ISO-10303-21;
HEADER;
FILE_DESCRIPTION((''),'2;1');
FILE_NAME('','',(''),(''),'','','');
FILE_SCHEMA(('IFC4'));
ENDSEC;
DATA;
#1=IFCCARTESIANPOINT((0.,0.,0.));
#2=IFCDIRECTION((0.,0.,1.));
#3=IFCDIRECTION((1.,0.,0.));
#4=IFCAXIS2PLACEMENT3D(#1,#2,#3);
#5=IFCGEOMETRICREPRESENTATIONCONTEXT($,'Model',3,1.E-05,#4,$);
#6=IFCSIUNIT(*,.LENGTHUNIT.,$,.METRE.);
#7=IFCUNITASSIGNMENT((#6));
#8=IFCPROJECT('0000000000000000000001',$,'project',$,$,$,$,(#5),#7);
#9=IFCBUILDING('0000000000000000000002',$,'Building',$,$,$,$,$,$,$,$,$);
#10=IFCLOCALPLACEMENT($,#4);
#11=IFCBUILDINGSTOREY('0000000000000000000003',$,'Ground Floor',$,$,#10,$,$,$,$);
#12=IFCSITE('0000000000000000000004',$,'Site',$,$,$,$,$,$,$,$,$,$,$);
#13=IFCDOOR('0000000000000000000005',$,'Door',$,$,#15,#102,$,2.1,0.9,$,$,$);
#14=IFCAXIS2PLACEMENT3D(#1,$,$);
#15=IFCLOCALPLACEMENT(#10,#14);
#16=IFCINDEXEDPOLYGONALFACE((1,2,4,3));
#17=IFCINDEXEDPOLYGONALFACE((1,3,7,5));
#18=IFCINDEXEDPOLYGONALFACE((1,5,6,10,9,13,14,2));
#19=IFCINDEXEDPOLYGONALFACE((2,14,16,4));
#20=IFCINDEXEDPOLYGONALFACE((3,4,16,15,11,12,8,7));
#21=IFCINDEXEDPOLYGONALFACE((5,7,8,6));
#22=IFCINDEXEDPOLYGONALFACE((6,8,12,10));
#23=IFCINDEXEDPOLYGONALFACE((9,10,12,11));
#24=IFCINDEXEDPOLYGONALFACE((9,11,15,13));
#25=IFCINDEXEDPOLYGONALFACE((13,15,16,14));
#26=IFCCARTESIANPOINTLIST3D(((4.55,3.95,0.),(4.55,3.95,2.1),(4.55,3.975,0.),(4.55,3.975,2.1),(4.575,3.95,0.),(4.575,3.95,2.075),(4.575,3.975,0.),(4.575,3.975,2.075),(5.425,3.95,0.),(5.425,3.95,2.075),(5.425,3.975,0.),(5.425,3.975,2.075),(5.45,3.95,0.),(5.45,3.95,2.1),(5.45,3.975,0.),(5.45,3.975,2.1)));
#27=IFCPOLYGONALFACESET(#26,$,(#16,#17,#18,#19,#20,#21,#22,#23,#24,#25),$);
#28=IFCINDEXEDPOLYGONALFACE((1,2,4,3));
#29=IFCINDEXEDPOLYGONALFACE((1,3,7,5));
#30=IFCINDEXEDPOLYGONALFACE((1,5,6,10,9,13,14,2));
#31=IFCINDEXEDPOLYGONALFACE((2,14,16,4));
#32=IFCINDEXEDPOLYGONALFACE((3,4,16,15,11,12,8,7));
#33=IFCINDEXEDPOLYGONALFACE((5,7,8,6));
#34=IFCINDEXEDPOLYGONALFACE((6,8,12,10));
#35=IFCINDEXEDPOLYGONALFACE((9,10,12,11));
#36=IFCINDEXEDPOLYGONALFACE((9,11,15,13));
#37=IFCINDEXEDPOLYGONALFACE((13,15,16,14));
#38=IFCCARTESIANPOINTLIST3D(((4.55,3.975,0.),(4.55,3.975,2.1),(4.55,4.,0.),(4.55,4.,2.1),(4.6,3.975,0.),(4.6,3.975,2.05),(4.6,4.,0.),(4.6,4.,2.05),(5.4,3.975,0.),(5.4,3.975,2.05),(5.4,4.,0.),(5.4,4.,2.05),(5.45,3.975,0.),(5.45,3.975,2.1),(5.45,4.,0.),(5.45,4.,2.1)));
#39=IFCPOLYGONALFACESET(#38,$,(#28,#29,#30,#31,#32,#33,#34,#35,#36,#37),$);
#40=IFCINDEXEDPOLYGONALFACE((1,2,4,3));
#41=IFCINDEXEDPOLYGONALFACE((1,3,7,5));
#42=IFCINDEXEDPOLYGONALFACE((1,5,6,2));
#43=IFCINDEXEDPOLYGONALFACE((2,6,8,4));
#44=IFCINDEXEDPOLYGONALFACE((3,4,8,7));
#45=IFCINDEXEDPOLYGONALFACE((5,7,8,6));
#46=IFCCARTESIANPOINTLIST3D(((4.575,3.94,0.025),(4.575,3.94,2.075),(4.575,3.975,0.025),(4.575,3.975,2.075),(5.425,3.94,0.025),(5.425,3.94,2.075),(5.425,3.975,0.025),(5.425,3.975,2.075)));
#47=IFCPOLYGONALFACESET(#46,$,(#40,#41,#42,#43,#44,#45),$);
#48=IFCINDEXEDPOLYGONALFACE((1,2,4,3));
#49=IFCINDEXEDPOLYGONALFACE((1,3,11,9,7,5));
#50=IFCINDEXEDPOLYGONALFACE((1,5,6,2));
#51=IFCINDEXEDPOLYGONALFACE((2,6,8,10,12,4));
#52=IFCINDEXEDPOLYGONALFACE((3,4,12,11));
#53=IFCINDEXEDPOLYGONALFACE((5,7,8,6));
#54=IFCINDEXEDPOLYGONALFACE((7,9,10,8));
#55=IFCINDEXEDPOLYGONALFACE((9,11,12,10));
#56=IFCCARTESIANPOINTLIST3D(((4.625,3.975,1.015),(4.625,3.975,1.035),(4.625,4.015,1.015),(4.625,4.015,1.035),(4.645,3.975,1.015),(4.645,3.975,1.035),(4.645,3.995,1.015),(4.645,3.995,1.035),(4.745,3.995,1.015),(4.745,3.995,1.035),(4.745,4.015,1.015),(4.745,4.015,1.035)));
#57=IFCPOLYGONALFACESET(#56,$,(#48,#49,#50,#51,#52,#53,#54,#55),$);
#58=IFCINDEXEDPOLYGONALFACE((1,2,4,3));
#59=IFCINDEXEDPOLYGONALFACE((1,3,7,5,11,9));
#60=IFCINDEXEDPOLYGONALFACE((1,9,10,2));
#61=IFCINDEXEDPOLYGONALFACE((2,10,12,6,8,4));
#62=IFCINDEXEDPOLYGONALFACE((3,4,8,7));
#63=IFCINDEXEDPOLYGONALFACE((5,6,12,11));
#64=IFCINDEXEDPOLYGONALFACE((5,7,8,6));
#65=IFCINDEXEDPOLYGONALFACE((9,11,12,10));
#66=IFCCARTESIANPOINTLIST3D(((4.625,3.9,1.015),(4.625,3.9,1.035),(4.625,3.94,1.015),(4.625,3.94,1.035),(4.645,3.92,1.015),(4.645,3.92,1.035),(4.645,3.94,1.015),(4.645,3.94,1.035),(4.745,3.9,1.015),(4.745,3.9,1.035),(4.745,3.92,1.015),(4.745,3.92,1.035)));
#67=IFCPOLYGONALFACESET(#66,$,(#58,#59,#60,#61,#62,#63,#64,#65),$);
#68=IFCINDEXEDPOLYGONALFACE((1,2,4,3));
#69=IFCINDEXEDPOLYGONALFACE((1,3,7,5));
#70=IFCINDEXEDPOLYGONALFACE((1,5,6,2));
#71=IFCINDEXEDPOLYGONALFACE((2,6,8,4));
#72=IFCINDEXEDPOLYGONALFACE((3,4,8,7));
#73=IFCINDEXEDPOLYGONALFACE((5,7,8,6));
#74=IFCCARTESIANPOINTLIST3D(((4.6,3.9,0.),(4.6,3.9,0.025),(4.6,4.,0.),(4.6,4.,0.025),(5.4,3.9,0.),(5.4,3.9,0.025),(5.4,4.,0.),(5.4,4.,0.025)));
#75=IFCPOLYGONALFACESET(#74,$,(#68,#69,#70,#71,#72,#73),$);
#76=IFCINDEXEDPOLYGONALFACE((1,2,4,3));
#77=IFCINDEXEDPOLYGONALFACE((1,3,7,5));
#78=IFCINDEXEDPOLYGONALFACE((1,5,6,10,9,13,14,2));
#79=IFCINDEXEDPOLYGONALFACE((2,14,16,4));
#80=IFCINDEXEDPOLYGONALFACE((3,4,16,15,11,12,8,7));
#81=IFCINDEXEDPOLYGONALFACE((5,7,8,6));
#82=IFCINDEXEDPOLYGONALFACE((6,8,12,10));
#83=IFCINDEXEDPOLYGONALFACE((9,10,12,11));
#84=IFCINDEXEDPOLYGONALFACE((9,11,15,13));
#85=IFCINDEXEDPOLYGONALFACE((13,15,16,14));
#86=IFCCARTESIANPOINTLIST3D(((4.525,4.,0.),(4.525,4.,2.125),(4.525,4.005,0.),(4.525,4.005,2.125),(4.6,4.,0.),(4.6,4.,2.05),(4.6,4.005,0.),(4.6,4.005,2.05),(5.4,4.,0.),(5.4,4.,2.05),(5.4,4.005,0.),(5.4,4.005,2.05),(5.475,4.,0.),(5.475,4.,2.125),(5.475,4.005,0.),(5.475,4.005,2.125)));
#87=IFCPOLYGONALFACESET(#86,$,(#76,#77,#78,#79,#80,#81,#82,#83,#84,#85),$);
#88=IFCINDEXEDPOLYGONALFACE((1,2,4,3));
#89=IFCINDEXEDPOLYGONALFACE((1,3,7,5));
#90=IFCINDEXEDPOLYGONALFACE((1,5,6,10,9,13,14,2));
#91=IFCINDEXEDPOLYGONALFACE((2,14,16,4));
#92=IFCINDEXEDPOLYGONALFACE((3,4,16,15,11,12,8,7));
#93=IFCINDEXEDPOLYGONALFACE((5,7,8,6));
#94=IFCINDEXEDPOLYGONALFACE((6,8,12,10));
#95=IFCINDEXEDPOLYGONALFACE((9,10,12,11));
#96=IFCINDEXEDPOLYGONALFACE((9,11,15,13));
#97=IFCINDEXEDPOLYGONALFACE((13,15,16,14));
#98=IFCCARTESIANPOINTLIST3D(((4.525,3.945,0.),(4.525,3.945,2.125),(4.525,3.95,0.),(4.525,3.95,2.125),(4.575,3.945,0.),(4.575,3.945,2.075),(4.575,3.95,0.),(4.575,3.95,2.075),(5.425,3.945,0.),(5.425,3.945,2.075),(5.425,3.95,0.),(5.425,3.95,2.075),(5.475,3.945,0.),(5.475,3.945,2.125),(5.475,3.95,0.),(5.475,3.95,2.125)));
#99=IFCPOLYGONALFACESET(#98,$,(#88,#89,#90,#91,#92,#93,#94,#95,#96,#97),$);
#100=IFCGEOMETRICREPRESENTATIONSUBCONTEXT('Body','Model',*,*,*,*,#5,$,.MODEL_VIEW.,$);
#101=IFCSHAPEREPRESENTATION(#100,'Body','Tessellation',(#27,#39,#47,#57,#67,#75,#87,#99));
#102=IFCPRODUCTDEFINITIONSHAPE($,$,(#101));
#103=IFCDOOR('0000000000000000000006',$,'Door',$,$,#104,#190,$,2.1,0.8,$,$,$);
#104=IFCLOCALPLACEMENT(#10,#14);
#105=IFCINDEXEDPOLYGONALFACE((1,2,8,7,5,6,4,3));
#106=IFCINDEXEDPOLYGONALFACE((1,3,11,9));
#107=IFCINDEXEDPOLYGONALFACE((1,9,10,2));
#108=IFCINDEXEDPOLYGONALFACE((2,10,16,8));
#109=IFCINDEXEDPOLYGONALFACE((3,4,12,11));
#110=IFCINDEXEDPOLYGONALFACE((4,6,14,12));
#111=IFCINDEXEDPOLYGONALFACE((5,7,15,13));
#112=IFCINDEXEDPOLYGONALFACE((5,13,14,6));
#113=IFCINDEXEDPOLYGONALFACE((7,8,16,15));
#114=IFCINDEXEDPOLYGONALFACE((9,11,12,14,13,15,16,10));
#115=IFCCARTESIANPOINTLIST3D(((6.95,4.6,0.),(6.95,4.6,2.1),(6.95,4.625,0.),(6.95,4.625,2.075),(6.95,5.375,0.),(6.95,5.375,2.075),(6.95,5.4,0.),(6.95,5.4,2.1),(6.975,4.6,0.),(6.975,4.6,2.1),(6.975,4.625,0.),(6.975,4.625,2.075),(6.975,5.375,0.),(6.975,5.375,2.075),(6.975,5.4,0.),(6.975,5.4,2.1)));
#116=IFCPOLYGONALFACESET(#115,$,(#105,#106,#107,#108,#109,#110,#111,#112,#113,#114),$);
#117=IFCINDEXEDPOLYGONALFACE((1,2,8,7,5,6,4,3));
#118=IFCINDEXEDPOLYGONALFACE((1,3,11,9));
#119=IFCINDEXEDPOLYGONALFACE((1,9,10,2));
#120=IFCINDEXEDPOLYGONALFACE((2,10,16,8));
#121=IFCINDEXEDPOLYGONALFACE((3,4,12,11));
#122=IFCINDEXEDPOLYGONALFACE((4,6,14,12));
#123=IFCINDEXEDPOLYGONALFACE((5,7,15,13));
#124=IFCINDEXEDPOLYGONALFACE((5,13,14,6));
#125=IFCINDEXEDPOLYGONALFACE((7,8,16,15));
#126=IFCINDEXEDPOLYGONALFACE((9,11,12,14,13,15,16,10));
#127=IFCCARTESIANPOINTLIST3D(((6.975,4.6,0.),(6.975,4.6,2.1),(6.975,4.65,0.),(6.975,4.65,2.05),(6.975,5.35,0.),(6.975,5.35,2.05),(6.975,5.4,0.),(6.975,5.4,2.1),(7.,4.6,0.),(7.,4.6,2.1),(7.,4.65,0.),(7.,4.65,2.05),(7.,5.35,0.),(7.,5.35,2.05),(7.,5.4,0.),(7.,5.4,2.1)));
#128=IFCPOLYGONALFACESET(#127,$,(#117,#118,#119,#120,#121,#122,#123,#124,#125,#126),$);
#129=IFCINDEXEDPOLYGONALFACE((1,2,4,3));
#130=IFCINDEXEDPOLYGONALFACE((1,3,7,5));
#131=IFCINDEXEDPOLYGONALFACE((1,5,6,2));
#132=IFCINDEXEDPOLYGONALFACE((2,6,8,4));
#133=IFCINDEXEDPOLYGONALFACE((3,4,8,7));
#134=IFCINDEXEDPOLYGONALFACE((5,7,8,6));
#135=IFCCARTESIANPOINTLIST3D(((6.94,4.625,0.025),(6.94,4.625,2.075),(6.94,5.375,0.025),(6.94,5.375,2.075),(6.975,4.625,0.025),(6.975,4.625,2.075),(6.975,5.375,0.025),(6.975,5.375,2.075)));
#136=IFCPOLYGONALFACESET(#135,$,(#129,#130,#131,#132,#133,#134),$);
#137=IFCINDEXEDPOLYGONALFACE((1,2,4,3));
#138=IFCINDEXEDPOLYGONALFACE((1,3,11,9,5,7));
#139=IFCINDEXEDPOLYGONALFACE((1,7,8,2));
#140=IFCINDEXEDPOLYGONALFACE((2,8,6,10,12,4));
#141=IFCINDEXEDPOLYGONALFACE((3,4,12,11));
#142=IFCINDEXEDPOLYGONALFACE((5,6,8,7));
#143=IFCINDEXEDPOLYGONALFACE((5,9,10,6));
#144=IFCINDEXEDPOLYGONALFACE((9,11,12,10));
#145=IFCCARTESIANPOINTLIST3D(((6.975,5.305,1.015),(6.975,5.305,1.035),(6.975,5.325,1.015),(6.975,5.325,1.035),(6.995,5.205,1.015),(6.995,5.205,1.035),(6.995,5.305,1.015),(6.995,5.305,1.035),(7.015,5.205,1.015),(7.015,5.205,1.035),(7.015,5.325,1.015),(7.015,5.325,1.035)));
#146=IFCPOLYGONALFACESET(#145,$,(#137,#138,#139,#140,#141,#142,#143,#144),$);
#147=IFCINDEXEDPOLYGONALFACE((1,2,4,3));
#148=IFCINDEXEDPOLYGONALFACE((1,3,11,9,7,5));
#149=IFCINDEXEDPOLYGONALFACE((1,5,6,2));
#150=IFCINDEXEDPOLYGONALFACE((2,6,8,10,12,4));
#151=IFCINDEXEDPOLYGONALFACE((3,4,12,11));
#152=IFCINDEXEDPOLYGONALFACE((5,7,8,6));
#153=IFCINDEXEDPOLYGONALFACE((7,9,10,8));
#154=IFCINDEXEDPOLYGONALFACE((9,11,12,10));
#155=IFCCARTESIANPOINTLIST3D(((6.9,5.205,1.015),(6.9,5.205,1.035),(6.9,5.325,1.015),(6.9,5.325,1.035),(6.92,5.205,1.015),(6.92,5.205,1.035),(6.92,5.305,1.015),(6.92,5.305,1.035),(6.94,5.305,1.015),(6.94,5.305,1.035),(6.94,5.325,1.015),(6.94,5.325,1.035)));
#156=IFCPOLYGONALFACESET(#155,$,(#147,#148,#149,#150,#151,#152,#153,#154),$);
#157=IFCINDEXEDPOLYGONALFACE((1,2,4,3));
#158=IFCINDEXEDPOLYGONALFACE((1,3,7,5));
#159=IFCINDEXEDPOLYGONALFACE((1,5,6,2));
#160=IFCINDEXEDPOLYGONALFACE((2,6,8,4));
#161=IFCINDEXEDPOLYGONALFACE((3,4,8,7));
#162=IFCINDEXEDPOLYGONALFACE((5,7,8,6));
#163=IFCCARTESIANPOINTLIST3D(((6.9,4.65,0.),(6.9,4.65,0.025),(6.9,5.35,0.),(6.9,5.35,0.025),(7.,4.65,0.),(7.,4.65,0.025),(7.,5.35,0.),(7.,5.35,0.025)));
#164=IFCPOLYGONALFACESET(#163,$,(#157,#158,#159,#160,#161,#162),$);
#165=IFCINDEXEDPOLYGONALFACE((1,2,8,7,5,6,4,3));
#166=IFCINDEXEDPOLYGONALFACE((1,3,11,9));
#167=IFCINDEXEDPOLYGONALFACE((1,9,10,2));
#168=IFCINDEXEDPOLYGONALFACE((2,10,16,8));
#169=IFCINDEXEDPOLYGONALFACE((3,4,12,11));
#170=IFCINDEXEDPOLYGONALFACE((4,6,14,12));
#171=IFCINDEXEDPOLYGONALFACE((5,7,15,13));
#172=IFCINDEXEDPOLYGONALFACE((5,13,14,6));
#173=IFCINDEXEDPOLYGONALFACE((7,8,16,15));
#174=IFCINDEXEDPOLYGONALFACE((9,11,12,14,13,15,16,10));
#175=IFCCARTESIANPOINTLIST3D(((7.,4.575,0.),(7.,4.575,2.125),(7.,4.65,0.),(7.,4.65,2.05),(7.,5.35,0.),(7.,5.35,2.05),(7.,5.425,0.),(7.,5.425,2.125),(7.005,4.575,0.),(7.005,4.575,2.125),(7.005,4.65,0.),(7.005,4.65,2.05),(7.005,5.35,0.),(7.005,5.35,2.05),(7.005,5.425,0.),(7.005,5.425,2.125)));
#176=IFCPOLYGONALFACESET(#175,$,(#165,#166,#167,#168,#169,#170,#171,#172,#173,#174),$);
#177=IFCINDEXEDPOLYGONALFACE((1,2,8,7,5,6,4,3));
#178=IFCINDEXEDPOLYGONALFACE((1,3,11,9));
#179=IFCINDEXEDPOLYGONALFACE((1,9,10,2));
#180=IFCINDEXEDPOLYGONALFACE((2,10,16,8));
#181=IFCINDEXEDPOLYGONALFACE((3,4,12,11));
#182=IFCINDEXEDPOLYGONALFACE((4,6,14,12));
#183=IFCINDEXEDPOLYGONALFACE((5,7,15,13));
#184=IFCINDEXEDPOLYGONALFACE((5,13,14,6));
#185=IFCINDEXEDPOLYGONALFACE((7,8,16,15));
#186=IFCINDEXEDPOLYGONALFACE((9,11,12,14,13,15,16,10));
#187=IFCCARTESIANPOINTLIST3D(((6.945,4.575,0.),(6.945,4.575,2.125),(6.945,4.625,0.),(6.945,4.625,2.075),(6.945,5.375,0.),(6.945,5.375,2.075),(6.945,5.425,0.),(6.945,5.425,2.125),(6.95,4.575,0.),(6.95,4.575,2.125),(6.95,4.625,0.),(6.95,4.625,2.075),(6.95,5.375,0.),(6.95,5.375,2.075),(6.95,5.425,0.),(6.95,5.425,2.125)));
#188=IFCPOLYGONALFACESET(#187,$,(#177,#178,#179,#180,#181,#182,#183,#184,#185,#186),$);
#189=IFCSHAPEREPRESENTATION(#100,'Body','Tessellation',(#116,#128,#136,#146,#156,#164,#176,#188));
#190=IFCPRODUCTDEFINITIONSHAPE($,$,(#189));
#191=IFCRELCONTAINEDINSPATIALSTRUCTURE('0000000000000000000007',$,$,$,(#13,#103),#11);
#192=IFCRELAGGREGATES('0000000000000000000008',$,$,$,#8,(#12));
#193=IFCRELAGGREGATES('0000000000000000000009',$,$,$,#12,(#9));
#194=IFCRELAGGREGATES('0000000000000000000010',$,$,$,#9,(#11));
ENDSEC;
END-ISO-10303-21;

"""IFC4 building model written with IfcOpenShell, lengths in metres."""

from ifc_helpers import new_model, si_unit, frame, origin_with_axes, place, context, subcontext, project, spatial, line, indexed_curve, outline, extrude, element, save


model = new_model("IFC4")

# Units and contexts
model_context = context("Model", 3, precision=1e-05, world=origin_with_axes())
body_context = subcontext(model_context, "Body", "Model", "MODEL_VIEW")
ifc_project = project(units=[si_unit("LENGTHUNIT", "METRE")], contexts=[model_context])

# Site, building, storey
site = spatial("IfcSite", under=ifc_project, Name="Site")
building = spatial("IfcBuilding", under=site, Name="Building")
storey_placement = place(None, origin_with_axes())
storey = spatial("IfcBuildingStorey", under=building, at=storey_placement, Name="Ground Floor")

# Doors
door_1_placement = place(storey_placement, frame((5.45, 4.0, 0.0), z_axis=(0.0, 0.0, 1.0), x_axis=(-1.0, 0.0, 0.0)))
element("IfcDoor", 1, at=door_1_placement, inside=storey, Name="Door", OverallHeight=2.1, OverallWidth=0.9, context=body_context, shape_type="SweptSolid", body=[
    extrude(outline(indexed_curve([(0.0, 0.0), (0.0, 2.1), (0.9, 2.1), (0.9, 0.0), (0.875, 0.0), (0.875, 2.075), (0.025, 2.075), (0.025, 0.0)], segments=[line(1, 2, 3, 4, 5, 6, 7, 8, 1)])), frame((0.0, 0.025, 0.0), z_axis=(0.0, -1.0, 0.0), x_axis=(1.0, 0.0, 0.0)), (0.0, 0.0, -1.0), 0.025),
    extrude(outline(indexed_curve([(0.0, 0.0), (0.0, 2.1), (0.9, 2.1), (0.9, 0.0), (0.85, 0.0), (0.85, 2.05), (0.05, 2.05), (0.05, 0.0)], segments=[line(1, 2, 3, 4, 5, 6, 7, 8, 1)])), frame((0.0, 0.0, 0.0), z_axis=(0.0, -1.0, 0.0), x_axis=(1.0, 0.0, 0.0)), (0.0, 0.0, -1.0), 0.025),
    extrude(outline(indexed_curve([(0.0, 0.0), (0.85, 0.0), (0.85, 0.035), (0.0, 0.035)], segments=[line(1, 2, 3, 4, 1)])), frame((0.025, 0.025, 0.025), z_axis=(0.0, 0.0, 1.0), x_axis=(1.0, 0.0, 0.0)), (0.0, 0.0, 1.0), 2.05),
    extrude(outline(indexed_curve([(0.0, 0.0), (0.0, -0.04), (-0.12, -0.04), (-0.12, -0.02), (-0.02, -0.02), (-0.02, 0.0)], segments=[line(1, 2, 3, 4, 5, 6, 1)])), frame((0.825, 0.025, 1.015), z_axis=(0.0, 0.0, 1.0), x_axis=(1.0, 0.0, 0.0)), (0.0, 0.0, 1.0), 0.02),
    extrude(outline(indexed_curve([(0.0, 0.0), (0.0, 0.04), (-0.12, 0.04), (-0.12, 0.02), (-0.02, 0.02), (-0.02, 0.0)], segments=[line(1, 2, 3, 4, 5, 6, 1)])), frame((0.825, 0.06, 1.015), z_axis=(0.0, 0.0, 1.0), x_axis=(1.0, 0.0, 0.0)), (0.0, 0.0, 1.0), 0.02),
    extrude(outline(indexed_curve([(0.0, 0.0), (0.8, 0.0), (0.8, 0.1), (0.0, 0.1)], segments=[line(1, 2, 3, 4, 1)])), frame((0.05, 0.0, 0.0), z_axis=(0.0, 0.0, 1.0), x_axis=(1.0, 0.0, 0.0)), (0.0, 0.0, 1.0), 0.025),
    extrude(outline(indexed_curve([(0.0, 0.0), (0.0, 2.125), (0.95, 2.125), (0.95, 0.0), (0.875, 0.0), (0.875, 2.05), (0.075, 2.05), (0.075, 0.0)], segments=[line(1, 2, 3, 4, 5, 6, 7, 8, 1)])), frame((-0.025, -0.005, 0.0), z_axis=(0.0, -1.0, 0.0), x_axis=(1.0, 0.0, 0.0)), (0.0, 0.0, -1.0), 0.005),
    extrude(outline(indexed_curve([(0.0, 0.0), (0.0, 2.125), (0.95, 2.125), (0.95, 0.0), (0.9, 0.0), (0.9, 2.075), (0.05, 2.075), (0.05, 0.0)], segments=[line(1, 2, 3, 4, 5, 6, 7, 8, 1)])), frame((-0.025, 0.05, 0.0), z_axis=(0.0, -1.0, 0.0), x_axis=(1.0, 0.0, 0.0)), (0.0, 0.0, -1.0), 0.005),
])
door_2_placement = place(storey_placement, frame((7.0, 4.6, 0.0), z_axis=(0.0, 0.0, 1.0), x_axis=(0.0, 1.0, 0.0)))
element("IfcDoor", 2, at=door_2_placement, inside=storey, Name="Door", OverallHeight=2.1, OverallWidth=0.8, context=body_context, shape_type="SweptSolid", body=[
    extrude(outline(indexed_curve([(0.0, 0.0), (0.0, 2.1), (0.8, 2.1), (0.8, 0.0), (0.775, 0.0), (0.775, 2.075), (0.025, 2.075), (0.025, 0.0)], segments=[line(1, 2, 3, 4, 5, 6, 7, 8, 1)])), frame((0.0, 0.025, 0.0), z_axis=(0.0, -1.0, 0.0), x_axis=(1.0, 0.0, 0.0)), (0.0, 0.0, -1.0), 0.025),
    extrude(outline(indexed_curve([(0.0, 0.0), (0.0, 2.1), (0.8, 2.1), (0.8, 0.0), (0.75, 0.0), (0.75, 2.05), (0.05, 2.05), (0.05, 0.0)], segments=[line(1, 2, 3, 4, 5, 6, 7, 8, 1)])), frame((0.0, 0.0, 0.0), z_axis=(0.0, -1.0, 0.0), x_axis=(1.0, 0.0, 0.0)), (0.0, 0.0, -1.0), 0.025),
    extrude(outline(indexed_curve([(0.0, 0.0), (0.75, 0.0), (0.75, 0.035), (0.0, 0.035)], segments=[line(1, 2, 3, 4, 1)])), frame((0.025, 0.025, 0.025), z_axis=(0.0, 0.0, 1.0), x_axis=(1.0, 0.0, 0.0)), (0.0, 0.0, 1.0), 2.05),
    extrude(outline(indexed_curve([(0.0, 0.0), (0.0, -0.04), (-0.12, -0.04), (-0.12, -0.02), (-0.02, -0.02), (-0.02, 0.0)], segments=[line(1, 2, 3, 4, 5, 6, 1)])), frame((0.725, 0.025, 1.015), z_axis=(0.0, 0.0, 1.0), x_axis=(1.0, 0.0, 0.0)), (0.0, 0.0, 1.0), 0.02),
    extrude(outline(indexed_curve([(0.0, 0.0), (0.0, 0.04), (-0.12, 0.04), (-0.12, 0.02), (-0.02, 0.02), (-0.02, 0.0)], segments=[line(1, 2, 3, 4, 5, 6, 1)])), frame((0.725, 0.06, 1.015), z_axis=(0.0, 0.0, 1.0), x_axis=(1.0, 0.0, 0.0)), (0.0, 0.0, 1.0), 0.02),
    extrude(outline(indexed_curve([(0.0, 0.0), (0.7, 0.0), (0.7, 0.1), (0.0, 0.1)], segments=[line(1, 2, 3, 4, 1)])), frame((0.05, 0.0, 0.0), z_axis=(0.0, 0.0, 1.0), x_axis=(1.0, 0.0, 0.0)), (0.0, 0.0, 1.0), 0.025),
    extrude(outline(indexed_curve([(0.0, 0.0), (0.0, 2.125), (0.85, 2.125), (0.85, 0.0), (0.775, 0.0), (0.775, 2.05), (0.075, 2.05), (0.075, 0.0)], segments=[line(1, 2, 3, 4, 5, 6, 7, 8, 1)])), frame((-0.025, -0.005, 0.0), z_axis=(0.0, -1.0, 0.0), x_axis=(1.0, 0.0, 0.0)), (0.0, 0.0, -1.0), 0.005),
    extrude(outline(indexed_curve([(0.0, 0.0), (0.0, 2.125), (0.85, 2.125), (0.85, 0.0), (0.8, 0.0), (0.8, 2.075), (0.05, 2.075), (0.05, 0.0)], segments=[line(1, 2, 3, 4, 5, 6, 7, 8, 1)])), frame((-0.025, 0.05, 0.0), z_axis=(0.0, -1.0, 0.0), x_axis=(1.0, 0.0, 0.0)), (0.0, 0.0, -1.0), 0.005),
])

save(model, "model.ifc")
